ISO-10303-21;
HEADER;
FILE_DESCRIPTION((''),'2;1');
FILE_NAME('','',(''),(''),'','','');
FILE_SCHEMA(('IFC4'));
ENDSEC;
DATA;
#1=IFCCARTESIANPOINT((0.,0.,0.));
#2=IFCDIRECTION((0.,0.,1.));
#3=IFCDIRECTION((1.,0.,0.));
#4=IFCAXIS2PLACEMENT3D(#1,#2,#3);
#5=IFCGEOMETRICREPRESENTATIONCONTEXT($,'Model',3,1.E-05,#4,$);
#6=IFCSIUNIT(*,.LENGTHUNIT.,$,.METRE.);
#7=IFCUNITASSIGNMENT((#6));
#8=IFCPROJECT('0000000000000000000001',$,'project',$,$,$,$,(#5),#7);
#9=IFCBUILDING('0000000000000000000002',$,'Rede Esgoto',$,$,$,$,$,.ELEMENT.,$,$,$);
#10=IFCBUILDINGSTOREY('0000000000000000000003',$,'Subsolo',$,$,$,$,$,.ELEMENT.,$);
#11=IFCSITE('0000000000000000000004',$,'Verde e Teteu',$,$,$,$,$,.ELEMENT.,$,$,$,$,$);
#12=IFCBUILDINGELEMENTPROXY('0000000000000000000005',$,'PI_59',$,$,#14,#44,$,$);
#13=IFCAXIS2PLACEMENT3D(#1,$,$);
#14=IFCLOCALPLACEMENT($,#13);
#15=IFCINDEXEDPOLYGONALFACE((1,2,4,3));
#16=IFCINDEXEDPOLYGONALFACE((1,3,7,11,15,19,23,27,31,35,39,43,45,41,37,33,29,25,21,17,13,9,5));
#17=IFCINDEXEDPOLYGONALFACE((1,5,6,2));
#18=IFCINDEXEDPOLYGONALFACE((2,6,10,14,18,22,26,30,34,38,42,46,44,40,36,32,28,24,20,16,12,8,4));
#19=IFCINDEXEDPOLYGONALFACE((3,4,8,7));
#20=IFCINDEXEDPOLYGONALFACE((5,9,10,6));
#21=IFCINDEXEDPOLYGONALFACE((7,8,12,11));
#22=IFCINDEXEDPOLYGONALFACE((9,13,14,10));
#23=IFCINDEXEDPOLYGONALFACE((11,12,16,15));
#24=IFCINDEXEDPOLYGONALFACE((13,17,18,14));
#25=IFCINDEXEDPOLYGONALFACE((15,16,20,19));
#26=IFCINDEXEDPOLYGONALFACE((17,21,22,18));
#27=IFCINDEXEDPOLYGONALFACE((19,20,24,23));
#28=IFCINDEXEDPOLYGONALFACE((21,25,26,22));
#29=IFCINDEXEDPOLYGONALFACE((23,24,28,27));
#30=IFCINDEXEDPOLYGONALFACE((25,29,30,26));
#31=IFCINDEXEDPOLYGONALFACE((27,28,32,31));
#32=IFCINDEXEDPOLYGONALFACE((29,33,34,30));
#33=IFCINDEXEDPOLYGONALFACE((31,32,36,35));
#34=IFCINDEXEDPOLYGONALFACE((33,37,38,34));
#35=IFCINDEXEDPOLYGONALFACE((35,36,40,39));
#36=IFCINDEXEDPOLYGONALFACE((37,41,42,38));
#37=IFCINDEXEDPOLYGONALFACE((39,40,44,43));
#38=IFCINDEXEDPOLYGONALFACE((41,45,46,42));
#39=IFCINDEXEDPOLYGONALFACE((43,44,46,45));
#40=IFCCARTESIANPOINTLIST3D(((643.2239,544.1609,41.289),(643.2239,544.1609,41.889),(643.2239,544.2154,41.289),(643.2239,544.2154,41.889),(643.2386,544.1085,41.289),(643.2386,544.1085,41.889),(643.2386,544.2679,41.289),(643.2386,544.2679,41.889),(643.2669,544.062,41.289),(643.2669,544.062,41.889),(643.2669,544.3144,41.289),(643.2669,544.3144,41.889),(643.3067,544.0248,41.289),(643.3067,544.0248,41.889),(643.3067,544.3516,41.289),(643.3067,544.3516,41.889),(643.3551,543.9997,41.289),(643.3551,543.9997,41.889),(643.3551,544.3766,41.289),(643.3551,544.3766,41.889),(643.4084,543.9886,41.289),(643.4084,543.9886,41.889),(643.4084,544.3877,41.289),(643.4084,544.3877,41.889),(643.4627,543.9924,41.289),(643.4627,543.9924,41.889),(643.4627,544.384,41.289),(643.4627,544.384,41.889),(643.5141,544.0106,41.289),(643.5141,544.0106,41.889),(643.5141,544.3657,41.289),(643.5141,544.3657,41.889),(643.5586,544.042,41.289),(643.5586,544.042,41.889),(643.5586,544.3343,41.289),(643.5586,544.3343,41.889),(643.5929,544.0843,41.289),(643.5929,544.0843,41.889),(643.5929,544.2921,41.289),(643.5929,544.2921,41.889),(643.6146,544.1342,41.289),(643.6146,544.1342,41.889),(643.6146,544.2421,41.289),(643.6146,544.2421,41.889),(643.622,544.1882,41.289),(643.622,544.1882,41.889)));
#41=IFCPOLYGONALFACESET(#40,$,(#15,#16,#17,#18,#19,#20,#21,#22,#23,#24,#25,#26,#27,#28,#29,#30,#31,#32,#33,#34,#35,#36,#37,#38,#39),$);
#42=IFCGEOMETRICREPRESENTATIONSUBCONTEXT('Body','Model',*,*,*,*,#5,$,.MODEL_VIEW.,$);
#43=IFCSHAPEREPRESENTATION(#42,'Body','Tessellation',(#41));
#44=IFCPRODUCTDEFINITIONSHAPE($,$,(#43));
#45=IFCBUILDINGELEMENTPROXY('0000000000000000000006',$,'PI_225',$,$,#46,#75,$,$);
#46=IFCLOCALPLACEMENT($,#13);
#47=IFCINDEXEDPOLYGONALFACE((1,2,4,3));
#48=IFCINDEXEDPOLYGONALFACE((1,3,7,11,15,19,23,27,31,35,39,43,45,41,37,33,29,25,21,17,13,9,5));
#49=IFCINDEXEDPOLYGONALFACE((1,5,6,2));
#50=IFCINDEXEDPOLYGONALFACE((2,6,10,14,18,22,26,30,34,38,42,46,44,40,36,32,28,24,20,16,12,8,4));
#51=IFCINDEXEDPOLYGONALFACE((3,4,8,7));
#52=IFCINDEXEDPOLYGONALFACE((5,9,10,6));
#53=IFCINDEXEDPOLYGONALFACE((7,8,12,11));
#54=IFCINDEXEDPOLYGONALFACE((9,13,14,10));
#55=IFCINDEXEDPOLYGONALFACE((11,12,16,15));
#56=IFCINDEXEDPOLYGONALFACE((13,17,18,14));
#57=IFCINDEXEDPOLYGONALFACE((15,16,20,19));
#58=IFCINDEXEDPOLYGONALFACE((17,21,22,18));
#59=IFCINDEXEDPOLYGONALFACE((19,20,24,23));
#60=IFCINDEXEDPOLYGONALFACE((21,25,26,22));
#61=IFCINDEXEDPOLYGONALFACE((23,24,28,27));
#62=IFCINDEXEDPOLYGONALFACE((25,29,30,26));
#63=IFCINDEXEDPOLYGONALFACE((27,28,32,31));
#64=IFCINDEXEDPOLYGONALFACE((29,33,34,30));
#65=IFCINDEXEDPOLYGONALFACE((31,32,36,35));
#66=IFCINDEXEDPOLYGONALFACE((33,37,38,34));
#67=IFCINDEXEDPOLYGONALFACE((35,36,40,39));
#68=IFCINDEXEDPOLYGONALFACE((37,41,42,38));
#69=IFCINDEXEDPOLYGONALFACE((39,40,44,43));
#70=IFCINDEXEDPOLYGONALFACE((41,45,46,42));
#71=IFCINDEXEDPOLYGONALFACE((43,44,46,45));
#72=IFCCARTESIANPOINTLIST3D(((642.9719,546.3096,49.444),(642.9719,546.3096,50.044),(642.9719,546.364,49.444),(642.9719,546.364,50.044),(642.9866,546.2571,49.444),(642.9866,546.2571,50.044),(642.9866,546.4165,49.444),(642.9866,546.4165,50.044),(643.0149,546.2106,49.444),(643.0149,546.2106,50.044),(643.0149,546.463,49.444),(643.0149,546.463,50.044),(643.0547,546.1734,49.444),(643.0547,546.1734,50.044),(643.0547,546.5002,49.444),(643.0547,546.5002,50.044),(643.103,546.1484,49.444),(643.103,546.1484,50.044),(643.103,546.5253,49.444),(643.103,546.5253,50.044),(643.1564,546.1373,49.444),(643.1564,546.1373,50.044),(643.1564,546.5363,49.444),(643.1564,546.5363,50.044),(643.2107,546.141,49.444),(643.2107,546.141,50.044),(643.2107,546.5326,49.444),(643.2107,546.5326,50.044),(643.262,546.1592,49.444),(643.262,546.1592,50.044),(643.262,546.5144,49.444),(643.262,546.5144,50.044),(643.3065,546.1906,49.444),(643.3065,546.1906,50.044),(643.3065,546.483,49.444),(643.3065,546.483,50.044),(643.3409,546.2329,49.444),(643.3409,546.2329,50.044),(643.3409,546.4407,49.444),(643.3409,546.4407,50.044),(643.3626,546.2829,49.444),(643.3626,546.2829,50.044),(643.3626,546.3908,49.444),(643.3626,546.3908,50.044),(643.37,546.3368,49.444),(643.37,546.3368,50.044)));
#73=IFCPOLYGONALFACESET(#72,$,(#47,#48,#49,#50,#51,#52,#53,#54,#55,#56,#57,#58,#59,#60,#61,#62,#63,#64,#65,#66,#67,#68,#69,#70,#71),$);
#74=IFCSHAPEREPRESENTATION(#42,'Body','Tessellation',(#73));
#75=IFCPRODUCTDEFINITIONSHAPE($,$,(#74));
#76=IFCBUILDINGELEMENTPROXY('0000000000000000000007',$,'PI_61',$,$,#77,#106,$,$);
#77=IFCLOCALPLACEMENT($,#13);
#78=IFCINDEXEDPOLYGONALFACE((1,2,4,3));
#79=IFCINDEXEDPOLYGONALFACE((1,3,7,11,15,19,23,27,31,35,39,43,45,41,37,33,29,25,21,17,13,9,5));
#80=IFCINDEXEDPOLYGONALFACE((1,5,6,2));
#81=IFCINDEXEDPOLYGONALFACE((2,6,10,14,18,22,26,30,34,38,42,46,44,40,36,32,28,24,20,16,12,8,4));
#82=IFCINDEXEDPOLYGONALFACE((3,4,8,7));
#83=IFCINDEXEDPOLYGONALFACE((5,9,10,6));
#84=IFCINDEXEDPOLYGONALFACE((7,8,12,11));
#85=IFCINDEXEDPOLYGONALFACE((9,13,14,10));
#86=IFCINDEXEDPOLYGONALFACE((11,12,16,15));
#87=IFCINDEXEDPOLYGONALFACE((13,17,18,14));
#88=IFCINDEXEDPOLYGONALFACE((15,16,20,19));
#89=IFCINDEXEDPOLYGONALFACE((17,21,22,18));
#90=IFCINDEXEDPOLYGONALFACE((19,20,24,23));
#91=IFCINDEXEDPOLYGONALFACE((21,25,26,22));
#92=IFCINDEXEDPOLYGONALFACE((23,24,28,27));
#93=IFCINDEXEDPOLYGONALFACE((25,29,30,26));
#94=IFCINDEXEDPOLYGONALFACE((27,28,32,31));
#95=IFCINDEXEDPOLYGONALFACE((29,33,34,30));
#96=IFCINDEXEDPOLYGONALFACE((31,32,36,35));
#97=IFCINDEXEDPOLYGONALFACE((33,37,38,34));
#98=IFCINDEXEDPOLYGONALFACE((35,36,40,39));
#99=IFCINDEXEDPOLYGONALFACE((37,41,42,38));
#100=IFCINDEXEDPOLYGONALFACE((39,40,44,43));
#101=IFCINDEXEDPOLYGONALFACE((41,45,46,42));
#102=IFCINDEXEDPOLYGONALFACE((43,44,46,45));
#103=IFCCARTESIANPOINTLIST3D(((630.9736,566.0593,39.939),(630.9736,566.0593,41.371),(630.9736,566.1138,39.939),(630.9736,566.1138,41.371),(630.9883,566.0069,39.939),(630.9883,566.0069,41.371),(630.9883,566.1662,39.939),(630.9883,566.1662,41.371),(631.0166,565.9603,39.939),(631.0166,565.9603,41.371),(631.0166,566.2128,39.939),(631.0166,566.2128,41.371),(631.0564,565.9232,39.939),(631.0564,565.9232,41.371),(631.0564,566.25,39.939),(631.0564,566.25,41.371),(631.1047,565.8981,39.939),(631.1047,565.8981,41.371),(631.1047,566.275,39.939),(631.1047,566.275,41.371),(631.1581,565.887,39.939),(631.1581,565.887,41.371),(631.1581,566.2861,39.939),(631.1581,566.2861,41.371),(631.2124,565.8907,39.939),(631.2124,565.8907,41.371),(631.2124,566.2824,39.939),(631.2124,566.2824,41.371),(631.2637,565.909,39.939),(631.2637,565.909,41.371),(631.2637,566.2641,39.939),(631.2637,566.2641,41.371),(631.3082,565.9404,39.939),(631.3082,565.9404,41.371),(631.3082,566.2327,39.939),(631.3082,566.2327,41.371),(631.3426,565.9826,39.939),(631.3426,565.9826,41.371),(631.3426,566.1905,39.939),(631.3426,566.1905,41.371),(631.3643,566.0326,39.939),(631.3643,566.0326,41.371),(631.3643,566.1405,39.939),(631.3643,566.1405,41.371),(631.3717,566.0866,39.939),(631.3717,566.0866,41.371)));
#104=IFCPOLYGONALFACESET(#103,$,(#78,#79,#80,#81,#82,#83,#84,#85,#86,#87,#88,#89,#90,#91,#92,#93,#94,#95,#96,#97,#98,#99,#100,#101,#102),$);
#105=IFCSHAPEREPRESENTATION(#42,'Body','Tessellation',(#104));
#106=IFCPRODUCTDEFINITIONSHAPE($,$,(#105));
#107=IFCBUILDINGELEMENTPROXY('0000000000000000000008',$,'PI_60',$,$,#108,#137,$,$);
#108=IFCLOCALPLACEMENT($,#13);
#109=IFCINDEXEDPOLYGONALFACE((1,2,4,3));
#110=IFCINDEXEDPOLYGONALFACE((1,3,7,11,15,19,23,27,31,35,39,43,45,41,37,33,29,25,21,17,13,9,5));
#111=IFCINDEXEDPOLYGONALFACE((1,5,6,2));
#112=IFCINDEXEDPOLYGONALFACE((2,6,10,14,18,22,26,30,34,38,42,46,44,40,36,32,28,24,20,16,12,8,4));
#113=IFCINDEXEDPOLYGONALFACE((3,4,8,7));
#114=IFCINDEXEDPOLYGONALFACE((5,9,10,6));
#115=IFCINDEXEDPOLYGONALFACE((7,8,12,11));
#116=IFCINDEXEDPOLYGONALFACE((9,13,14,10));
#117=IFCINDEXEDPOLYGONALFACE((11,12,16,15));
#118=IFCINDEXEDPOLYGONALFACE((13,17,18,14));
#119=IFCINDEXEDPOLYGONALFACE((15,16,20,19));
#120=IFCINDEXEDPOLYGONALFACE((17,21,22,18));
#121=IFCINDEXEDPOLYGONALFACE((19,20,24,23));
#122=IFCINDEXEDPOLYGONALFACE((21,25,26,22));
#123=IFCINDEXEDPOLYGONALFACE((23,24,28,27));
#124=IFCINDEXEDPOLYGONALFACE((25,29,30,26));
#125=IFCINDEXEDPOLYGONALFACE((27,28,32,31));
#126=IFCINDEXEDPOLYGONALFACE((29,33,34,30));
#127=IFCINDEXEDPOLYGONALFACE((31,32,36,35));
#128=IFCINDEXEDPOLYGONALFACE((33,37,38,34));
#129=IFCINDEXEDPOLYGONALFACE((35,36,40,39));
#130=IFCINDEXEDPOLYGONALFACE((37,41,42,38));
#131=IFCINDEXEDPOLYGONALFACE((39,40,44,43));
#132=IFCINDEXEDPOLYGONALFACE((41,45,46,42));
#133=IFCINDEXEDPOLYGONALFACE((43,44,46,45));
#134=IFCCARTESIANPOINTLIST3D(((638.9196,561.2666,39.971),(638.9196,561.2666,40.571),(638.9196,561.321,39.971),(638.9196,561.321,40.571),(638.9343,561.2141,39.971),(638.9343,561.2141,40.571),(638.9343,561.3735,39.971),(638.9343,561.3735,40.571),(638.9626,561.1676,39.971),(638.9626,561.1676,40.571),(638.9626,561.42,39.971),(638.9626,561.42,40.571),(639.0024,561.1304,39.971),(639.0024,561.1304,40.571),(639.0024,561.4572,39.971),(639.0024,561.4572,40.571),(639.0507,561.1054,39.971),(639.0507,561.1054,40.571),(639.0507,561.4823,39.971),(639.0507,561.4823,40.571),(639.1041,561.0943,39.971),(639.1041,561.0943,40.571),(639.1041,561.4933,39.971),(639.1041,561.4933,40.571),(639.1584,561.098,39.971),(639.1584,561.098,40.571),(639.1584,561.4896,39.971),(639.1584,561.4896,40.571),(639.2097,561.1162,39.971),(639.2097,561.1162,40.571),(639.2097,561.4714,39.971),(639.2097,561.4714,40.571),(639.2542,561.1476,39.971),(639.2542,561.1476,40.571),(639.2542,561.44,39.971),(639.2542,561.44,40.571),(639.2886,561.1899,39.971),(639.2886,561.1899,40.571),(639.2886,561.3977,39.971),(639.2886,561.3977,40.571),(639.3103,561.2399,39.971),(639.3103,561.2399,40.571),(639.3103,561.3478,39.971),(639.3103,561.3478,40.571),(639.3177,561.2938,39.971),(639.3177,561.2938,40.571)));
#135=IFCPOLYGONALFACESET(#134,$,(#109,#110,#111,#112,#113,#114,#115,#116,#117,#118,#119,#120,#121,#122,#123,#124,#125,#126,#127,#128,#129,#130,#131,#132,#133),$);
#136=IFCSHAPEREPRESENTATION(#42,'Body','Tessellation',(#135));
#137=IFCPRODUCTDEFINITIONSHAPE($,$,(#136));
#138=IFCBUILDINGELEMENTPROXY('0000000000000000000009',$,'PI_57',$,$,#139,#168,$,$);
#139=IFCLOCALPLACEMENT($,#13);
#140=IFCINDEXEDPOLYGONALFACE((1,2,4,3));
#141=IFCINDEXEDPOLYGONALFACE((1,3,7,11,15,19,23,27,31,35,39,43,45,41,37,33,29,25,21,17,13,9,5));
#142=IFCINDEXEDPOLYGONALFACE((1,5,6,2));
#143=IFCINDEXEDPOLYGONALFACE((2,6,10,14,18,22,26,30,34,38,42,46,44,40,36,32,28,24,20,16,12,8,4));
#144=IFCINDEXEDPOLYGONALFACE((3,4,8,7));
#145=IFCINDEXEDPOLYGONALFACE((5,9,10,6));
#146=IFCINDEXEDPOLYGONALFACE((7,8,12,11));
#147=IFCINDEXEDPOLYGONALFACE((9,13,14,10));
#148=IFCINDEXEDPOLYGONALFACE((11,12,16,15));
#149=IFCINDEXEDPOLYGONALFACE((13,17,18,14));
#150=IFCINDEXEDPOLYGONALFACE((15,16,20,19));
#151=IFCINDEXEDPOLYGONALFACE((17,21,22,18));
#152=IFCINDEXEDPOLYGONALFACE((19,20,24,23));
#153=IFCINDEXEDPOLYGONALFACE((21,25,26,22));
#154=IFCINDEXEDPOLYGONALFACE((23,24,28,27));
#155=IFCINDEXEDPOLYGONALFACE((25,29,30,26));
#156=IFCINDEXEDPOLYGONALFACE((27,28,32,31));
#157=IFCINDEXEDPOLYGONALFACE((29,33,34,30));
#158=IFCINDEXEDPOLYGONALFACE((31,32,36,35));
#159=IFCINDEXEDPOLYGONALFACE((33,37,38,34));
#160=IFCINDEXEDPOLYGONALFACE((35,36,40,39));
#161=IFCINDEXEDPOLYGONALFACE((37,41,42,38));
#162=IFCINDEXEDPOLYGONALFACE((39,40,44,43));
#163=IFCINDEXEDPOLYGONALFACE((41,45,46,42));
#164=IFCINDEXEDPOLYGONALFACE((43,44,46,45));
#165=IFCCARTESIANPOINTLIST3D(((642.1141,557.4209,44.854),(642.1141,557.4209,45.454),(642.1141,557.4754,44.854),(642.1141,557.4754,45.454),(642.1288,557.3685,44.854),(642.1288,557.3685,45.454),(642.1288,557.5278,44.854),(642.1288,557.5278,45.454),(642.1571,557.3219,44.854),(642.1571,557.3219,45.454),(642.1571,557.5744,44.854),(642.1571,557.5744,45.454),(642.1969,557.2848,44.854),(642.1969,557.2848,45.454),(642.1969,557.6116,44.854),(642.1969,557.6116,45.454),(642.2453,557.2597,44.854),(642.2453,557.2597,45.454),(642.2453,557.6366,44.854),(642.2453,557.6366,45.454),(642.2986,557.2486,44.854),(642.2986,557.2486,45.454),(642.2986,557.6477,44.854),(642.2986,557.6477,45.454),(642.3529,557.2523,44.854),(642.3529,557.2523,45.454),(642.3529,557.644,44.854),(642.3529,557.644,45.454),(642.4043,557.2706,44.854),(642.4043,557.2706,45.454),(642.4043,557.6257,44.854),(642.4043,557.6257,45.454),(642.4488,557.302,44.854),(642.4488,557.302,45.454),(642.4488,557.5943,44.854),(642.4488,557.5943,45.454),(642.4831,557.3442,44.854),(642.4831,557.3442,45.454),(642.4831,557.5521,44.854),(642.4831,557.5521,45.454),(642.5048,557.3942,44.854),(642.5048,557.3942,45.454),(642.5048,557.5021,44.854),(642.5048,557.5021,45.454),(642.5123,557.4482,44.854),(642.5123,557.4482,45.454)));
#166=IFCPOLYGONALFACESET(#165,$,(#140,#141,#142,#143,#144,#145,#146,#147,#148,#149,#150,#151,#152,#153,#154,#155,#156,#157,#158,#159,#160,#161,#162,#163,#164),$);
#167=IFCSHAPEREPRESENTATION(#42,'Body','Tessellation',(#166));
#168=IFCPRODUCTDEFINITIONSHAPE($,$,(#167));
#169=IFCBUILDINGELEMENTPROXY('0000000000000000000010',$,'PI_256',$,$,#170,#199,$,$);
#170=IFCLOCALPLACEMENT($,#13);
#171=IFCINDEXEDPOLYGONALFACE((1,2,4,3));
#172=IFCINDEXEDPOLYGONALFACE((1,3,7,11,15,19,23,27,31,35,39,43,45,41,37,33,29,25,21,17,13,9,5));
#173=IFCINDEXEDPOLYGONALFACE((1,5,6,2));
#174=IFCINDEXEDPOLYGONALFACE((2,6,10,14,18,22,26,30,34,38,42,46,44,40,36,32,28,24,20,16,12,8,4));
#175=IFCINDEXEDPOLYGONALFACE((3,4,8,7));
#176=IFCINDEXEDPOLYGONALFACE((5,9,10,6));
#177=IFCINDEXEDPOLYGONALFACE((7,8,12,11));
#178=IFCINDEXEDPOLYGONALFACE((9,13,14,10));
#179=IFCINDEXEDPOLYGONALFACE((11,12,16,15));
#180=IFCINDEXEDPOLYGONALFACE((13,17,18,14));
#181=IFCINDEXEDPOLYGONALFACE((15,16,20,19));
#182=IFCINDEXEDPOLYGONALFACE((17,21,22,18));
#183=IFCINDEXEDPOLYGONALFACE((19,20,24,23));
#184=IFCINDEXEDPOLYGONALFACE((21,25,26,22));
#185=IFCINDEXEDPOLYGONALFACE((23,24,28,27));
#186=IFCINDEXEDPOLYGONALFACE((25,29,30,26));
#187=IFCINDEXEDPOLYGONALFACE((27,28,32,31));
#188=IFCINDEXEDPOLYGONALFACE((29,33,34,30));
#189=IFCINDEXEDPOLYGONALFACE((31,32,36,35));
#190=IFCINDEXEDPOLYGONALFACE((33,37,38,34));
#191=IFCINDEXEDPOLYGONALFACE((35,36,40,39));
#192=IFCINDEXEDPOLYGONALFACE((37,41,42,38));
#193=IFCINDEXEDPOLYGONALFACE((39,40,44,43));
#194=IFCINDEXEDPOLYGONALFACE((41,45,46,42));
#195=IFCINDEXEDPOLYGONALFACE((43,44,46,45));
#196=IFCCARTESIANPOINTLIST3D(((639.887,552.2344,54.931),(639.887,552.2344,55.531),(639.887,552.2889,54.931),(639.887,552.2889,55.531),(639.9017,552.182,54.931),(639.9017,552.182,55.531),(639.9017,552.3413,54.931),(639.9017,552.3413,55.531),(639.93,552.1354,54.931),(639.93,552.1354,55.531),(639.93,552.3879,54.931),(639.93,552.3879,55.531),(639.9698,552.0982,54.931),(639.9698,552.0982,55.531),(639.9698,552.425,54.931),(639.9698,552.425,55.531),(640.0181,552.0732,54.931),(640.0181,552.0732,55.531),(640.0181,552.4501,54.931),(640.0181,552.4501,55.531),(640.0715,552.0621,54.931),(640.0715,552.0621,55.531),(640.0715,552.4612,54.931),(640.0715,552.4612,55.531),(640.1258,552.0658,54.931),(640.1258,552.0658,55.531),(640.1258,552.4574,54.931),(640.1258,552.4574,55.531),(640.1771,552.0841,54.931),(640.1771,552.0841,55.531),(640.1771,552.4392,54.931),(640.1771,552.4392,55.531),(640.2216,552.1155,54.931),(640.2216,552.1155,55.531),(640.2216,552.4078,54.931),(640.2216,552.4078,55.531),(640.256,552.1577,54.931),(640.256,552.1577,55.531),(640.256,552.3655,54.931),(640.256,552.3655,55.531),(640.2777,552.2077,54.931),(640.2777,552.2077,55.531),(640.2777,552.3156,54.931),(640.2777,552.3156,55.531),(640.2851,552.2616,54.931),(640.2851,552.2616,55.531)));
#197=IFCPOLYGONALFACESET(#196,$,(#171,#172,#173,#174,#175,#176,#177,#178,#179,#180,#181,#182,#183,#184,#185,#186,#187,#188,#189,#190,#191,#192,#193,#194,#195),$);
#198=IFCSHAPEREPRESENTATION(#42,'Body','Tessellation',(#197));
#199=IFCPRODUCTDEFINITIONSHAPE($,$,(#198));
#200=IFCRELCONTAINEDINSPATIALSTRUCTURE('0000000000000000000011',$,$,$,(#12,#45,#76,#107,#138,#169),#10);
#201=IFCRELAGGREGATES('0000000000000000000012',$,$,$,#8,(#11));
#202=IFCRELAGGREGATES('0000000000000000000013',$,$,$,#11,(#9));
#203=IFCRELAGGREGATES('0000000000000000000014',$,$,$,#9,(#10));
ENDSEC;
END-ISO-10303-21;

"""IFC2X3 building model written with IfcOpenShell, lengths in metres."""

from ifc_helpers import new_model, si_unit, frame, origin_with_axes, origin_2d, place, context, subcontext, project, spatial, circle, extrude, element, save


model = new_model("IFC2X3")

# Units and contexts
model_context = context("Model", 3, precision=1e-05, world=origin_with_axes())
body_context = subcontext(model_context, "Body", "Model", "MODEL_VIEW")
ifc_project = project(units=[si_unit("LENGTHUNIT", "METRE")], contexts=[model_context])

# Site, building, storey
site = spatial("IfcSite", under=ifc_project, Name="Verde e Teteu", CompositionType="ELEMENT")
building = spatial("IfcBuilding", under=site, Name="Rede Esgoto", CompositionType="ELEMENT")
storey = spatial("IfcBuildingStorey", under=building, Name="Subsolo", CompositionType="ELEMENT")

# Building element proxies
proxy_1_placement = place(None, frame((643.422, 544.1882, 41.289), z_axis=(0.0, 0.0, 1.0), x_axis=(1.0, 0.0, 0.0)))
element("IfcBuildingElementProxy", 1, at=proxy_1_placement, inside=storey, Name="PI_59", context=body_context, shape_type="SweptSolid", body=[
    extrude(circle(Radius=0.2, at=origin_2d()), origin_with_axes(), (0.0, 0.0, 1.0), 0.6),
])
proxy_2_placement = place(None, frame((643.17, 546.3368, 49.444), z_axis=(0.0, 0.0, 1.0), x_axis=(1.0, 0.0, 0.0)))
element("IfcBuildingElementProxy", 2, at=proxy_2_placement, inside=storey, Name="PI_225", context=body_context, shape_type="SweptSolid", body=[
    extrude(circle(Radius=0.2, at=origin_2d()), origin_with_axes(), (0.0, 0.0, 1.0), 0.6),
])
proxy_3_placement = place(None, frame((631.1717, 566.0866, 39.939), z_axis=(0.0, 0.0, 1.0), x_axis=(1.0, 0.0, 0.0)))
element("IfcBuildingElementProxy", 3, at=proxy_3_placement, inside=storey, Name="PI_61", context=body_context, shape_type="SweptSolid", body=[
    extrude(circle(Radius=0.2, at=origin_2d()), origin_with_axes(), (0.0, 0.0, 1.0), 1.432),
])
for number, where, z_axis, x_axis, name in (
    (4, (639.1177, 561.2938, 39.971), (0.0, 0.0, 1.0), (1.0, 0.0, 0.0), "PI_60"),
    (5, (642.3123, 557.4482, 44.854), (0.0, 0.0, 1.0), (1.0, 0.0, 0.0), "PI_57"),
    (6, (640.0851, 552.2616, 54.931), (0.0, 0.0, 1.0), (1.0, 0.0, 0.0), "PI_256"),
):
    element("IfcBuildingElementProxy", number, at=place(None, frame(where, z_axis=z_axis, x_axis=x_axis)), inside=storey, Name=name, context=body_context, shape_type="SweptSolid", body=[
        extrude(circle(Radius=0.2, at=origin_2d()), origin_with_axes(), (0.0, 0.0, 1.0), 0.6),
    ])

save(model, "model.ifc")
